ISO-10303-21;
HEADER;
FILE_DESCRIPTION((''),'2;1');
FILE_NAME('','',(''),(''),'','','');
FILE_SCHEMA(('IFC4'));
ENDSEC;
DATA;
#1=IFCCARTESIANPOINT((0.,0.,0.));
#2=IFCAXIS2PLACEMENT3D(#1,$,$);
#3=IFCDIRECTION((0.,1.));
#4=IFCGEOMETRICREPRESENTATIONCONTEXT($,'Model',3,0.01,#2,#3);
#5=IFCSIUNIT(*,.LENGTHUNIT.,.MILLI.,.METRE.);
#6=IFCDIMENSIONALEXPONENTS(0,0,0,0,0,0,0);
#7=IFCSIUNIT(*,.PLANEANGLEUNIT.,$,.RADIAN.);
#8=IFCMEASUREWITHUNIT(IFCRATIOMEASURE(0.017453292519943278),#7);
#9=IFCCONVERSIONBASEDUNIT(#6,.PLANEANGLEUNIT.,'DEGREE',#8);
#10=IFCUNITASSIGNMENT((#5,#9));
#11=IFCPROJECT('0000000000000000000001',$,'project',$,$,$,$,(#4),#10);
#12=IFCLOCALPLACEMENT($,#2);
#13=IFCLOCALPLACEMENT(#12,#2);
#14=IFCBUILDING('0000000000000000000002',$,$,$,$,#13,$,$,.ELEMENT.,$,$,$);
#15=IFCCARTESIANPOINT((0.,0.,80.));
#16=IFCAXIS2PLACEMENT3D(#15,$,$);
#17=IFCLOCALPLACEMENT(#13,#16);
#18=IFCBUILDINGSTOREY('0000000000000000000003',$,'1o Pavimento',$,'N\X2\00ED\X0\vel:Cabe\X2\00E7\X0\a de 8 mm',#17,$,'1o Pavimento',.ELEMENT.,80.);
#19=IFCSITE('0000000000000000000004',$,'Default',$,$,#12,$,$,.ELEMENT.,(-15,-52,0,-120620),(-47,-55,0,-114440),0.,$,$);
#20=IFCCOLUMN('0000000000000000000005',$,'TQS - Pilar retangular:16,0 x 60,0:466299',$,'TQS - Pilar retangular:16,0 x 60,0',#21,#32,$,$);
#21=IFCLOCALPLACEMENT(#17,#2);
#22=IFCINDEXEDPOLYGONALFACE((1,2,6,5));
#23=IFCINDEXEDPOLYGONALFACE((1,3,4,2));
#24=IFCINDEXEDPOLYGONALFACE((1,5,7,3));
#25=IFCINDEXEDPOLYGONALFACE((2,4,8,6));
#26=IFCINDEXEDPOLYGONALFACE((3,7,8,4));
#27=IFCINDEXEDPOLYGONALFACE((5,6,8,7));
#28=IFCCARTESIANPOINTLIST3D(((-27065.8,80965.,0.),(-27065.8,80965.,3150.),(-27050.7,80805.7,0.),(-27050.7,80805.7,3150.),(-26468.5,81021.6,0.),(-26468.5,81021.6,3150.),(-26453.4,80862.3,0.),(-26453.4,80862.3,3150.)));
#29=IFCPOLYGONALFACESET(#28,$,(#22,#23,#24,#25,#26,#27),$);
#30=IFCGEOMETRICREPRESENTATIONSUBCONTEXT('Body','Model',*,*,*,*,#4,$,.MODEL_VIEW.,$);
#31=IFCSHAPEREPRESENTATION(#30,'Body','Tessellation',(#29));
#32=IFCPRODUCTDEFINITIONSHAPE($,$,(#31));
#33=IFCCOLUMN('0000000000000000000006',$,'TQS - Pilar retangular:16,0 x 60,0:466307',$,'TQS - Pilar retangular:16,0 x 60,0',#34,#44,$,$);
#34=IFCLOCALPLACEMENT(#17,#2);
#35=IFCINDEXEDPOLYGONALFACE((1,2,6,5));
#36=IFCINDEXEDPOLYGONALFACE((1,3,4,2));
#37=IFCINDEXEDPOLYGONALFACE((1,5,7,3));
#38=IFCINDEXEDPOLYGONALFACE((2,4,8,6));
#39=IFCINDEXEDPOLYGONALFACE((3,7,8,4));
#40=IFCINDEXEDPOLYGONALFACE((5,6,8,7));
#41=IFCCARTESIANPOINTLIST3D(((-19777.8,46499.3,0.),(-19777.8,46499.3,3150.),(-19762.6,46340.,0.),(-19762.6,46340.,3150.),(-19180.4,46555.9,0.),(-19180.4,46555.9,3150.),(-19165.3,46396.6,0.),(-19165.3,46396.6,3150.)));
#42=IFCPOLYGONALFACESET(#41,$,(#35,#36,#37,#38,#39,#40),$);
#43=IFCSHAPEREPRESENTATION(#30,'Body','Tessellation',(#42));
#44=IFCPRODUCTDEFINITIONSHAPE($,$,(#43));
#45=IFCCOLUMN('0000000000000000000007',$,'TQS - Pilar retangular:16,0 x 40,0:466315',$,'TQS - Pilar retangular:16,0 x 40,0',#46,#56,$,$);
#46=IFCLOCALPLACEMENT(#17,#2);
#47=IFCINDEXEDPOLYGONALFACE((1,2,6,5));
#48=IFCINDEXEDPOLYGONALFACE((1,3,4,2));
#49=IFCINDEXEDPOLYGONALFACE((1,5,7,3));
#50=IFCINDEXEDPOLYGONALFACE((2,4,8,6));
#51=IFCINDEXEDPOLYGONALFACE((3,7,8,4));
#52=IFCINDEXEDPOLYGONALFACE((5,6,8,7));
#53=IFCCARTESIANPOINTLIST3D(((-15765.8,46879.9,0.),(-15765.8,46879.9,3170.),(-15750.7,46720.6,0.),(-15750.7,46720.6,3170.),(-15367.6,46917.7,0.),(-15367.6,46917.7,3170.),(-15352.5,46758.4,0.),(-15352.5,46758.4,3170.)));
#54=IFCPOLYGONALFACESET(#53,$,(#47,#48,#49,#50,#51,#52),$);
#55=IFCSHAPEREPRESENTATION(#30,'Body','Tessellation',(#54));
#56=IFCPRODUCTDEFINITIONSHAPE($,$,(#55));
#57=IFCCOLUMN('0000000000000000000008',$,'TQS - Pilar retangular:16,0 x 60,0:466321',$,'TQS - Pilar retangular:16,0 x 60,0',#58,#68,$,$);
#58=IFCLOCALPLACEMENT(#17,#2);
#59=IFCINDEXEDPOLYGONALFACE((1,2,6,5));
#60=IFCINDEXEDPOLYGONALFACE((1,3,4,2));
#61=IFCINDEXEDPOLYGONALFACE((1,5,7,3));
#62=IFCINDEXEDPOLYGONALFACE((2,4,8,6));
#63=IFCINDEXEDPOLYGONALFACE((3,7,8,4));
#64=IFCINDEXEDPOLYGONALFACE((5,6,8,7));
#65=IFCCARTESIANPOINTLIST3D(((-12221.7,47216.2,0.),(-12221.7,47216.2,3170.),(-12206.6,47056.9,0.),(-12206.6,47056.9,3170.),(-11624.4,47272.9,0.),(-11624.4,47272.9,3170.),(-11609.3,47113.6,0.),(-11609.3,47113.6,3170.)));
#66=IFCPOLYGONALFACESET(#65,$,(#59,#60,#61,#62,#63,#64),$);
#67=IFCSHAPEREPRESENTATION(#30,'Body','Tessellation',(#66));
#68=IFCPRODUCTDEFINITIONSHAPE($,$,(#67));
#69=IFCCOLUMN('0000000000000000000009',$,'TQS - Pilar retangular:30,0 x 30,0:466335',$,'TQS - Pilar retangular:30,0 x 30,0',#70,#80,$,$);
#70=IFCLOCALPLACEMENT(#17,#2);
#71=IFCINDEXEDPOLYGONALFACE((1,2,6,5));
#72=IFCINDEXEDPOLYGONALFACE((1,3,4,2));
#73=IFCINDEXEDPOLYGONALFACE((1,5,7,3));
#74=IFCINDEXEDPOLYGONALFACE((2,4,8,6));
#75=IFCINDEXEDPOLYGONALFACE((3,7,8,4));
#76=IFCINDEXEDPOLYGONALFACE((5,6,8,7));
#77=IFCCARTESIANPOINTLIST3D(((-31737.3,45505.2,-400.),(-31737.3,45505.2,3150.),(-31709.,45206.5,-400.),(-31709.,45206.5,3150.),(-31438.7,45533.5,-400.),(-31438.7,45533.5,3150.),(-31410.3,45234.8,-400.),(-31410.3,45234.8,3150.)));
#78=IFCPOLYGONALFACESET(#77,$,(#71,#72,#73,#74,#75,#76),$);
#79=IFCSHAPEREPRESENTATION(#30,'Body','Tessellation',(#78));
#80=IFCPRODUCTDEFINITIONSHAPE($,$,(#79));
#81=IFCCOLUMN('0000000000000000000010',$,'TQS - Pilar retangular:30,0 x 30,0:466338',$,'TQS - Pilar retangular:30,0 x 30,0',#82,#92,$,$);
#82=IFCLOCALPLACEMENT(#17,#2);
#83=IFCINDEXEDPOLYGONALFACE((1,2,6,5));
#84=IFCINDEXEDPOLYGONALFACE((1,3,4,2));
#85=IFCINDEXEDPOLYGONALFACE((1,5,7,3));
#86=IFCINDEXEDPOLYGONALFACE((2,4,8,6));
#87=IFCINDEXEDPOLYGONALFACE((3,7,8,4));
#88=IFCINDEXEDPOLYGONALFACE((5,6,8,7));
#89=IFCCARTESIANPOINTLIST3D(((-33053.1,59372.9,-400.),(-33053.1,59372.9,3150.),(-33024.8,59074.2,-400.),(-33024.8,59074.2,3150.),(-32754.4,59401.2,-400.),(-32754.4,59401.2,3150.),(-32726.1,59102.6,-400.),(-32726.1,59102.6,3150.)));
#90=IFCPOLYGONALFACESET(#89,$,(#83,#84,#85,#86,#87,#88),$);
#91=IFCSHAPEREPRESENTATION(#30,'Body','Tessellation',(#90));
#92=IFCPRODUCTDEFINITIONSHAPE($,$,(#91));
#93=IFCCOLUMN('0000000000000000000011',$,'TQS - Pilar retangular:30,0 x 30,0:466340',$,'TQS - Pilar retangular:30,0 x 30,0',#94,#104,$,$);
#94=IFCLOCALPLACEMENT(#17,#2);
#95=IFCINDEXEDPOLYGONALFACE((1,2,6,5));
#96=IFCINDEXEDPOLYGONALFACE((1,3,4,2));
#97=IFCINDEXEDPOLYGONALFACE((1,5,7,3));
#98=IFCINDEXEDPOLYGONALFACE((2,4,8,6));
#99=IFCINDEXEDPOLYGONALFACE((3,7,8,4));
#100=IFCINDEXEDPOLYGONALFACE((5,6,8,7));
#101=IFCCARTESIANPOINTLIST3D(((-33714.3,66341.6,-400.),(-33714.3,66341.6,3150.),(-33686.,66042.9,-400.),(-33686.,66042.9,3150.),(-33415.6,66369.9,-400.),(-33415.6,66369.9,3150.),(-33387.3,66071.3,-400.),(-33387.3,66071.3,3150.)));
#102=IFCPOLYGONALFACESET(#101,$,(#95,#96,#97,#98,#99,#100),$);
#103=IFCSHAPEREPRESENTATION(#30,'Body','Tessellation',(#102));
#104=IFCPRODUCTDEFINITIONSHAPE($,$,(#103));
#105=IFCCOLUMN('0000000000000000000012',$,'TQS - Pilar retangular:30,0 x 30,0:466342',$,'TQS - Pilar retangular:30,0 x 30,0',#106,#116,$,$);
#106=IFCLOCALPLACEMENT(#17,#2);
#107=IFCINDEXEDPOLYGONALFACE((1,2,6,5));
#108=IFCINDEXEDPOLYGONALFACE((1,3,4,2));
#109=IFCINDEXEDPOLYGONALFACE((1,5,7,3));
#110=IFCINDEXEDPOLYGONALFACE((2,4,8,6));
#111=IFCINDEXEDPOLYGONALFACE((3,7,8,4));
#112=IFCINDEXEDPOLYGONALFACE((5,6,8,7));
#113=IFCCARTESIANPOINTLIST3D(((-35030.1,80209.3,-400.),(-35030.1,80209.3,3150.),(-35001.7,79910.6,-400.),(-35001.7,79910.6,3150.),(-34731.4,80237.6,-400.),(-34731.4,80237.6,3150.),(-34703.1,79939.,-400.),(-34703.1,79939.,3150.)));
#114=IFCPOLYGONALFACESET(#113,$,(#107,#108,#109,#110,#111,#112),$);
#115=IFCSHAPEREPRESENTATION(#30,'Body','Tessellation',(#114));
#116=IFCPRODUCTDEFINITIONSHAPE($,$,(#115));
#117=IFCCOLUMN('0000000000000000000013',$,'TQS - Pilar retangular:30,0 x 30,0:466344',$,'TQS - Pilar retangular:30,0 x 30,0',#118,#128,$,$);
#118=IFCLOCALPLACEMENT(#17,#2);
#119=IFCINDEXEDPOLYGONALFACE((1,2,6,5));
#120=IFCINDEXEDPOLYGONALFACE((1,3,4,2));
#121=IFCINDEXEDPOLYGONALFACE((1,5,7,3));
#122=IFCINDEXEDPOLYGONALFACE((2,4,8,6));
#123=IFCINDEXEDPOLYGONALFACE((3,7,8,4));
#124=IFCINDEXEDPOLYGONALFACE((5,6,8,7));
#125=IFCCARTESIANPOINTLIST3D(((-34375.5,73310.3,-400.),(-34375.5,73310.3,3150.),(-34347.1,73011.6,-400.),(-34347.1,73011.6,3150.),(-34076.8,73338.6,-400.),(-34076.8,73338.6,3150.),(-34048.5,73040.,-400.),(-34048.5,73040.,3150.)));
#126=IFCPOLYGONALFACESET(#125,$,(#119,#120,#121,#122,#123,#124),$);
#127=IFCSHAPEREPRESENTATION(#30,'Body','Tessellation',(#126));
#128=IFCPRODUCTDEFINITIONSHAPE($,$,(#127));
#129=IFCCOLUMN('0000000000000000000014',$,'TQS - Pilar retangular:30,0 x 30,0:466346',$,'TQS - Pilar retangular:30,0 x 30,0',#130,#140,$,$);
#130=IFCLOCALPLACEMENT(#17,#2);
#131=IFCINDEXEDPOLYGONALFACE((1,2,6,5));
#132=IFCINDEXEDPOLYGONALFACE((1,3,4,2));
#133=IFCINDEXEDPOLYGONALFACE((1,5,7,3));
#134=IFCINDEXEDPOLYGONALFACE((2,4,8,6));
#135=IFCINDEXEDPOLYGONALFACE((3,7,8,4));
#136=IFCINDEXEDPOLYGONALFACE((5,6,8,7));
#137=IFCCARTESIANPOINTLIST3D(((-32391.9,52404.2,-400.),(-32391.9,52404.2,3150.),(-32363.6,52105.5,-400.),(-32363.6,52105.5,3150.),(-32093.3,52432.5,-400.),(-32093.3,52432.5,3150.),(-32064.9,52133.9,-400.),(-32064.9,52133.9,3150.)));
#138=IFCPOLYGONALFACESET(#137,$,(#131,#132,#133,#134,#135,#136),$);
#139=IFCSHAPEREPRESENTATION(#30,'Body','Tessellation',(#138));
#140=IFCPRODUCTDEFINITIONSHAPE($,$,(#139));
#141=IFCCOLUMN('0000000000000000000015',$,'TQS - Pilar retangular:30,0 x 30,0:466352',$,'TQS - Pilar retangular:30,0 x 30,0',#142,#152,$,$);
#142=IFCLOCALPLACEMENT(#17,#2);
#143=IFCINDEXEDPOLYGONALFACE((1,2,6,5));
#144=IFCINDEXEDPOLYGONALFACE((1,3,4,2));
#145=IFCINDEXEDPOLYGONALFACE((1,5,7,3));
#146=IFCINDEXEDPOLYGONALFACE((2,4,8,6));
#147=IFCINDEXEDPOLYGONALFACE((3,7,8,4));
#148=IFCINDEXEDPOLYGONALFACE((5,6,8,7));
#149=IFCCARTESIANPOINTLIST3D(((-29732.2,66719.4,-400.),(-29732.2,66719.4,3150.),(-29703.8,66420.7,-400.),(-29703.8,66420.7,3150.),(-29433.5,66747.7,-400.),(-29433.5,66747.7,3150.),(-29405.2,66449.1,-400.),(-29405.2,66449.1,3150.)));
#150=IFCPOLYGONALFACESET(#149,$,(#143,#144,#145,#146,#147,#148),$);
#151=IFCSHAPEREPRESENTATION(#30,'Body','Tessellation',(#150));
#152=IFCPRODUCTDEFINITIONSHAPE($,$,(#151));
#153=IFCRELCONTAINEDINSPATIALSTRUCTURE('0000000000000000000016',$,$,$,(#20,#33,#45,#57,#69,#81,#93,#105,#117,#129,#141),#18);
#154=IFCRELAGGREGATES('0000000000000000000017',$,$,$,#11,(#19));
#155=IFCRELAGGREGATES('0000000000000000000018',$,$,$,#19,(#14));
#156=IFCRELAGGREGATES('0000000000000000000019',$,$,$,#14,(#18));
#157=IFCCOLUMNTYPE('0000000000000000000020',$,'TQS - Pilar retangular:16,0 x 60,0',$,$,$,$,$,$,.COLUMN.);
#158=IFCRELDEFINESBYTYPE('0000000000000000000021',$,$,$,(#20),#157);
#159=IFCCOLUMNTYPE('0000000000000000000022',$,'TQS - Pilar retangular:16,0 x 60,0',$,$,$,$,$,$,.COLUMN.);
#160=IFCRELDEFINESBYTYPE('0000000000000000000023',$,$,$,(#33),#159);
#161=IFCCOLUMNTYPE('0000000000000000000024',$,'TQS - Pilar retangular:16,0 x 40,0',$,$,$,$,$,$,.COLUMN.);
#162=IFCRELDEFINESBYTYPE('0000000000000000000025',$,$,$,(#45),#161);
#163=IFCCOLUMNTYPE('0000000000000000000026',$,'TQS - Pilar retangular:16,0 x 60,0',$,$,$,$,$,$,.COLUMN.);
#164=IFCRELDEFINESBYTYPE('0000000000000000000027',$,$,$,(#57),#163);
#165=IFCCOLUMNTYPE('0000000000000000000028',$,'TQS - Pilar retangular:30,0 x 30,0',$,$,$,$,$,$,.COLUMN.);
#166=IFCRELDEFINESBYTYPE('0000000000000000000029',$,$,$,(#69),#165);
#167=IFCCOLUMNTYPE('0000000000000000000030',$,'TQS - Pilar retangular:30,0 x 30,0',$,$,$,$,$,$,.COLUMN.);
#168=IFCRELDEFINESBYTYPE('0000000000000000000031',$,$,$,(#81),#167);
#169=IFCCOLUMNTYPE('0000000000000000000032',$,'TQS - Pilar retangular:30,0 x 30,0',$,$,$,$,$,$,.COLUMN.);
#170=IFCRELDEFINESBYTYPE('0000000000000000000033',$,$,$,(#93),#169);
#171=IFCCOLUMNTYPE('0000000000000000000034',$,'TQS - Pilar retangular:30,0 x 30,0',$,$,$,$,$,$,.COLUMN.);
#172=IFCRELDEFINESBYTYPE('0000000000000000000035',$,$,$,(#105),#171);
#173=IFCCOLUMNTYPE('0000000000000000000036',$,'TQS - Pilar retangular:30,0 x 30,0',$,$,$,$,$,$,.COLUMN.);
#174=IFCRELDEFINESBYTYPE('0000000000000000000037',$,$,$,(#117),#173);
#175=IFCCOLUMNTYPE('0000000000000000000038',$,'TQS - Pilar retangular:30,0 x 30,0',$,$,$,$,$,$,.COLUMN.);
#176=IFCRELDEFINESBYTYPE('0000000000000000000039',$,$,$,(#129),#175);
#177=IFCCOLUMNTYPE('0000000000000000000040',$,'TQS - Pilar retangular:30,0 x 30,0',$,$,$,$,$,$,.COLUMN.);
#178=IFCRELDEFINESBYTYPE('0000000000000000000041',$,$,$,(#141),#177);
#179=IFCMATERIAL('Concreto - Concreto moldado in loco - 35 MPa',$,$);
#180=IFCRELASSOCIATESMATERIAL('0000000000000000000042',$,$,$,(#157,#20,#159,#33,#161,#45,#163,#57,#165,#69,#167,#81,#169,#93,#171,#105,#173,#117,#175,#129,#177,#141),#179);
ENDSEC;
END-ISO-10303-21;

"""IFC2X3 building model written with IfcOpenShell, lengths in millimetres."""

from ifc_helpers import new_model, entity, si_unit, converted_unit, direction, frame, frame_2d, origin, origin_2d_with_axis, place, context, subcontext, project, spatial, rectangle, extrude, source, transform, mapped, material, type_object, type_shapes, element, save


model = new_model("IFC2X3")

# Units and contexts
model_context = context("Model", 3, precision=0.01, world=origin(), true_north=direction((0.0, 1.0)))
body_context = subcontext(model_context, "Body", "Model", "MODEL_VIEW")
ifc_project = project(units=[si_unit("LENGTHUNIT", "METRE", prefix="MILLI"), converted_unit("PLANEANGLEUNIT", "DEGREE", entity("IfcRatioMeasure", 0.017453292519943278), si_unit("PLANEANGLEUNIT", "RADIAN"), dimensions=[0, 0, 0, 0, 0, 0, 0])], contexts=[model_context])

# Site, building, storey
site_placement = place(None, origin())
site = spatial("IfcSite", under=ifc_project, at=site_placement, Name="Default", CompositionType="ELEMENT", RefLatitude=(-15, -52, 0, -120620), RefLongitude=(-47, -55, 0, -114440), RefElevation=0.0)
building_placement = place(site_placement, origin())
building = spatial("IfcBuilding", under=site, at=building_placement, CompositionType="ELEMENT")
storey_placement = place(building_placement, frame((0.0, 0.0, 80.0)))
storey = spatial("IfcBuildingStorey", under=building, at=storey_placement, Name="1o Pavimento", ObjectType="Nível:Cabeça de 8 mm", LongName="1o Pavimento", CompositionType="ELEMENT", Elevation=80.0)

# Columns
ifc_material = material(Name="Concreto - Concreto moldado in loco - 35 MPa")
column_type_1 = type_object("IfcColumnType", Name="TQS - Pilar retangular:16,0 x 60,0", PredefinedType="COLUMN", material=ifc_material)
shared_shape_1 = source(origin(), body_context, "Body", "SweptSolid", [
    extrude(rectangle(XDim=600.0, YDim=160.0, at=origin_2d_with_axis()), frame((-26759.6, 80913.6, 80.0), z_axis=(0.0, 0.0, 1.0), x_axis=(-0.995529, -0.094456, 0.0)), (0.0, 0.0, 1.0), 3150.0),
])
type_shapes(column_type_1, [shared_shape_1])
column_1_placement = place(storey_placement, frame((0.0, 0.0, -80.0)))
element("IfcColumn", 1, at=column_1_placement, inside=storey, type_object=column_type_1, material=ifc_material, Name="TQS - Pilar retangular:16,0 x 60,0:466299", ObjectType="TQS - Pilar retangular:16,0 x 60,0", context=body_context, shape_type="MappedRepresentation", body=[
    mapped(shared_shape_1, transform((0.0, 0.0, 0.0), scale=1.0)),
])
column_type_2 = type_object("IfcColumnType", Name="TQS - Pilar retangular:16,0 x 60,0", PredefinedType="COLUMN", material=ifc_material)
shared_shape_2 = source(origin(), body_context, "Body", "SweptSolid", [
    extrude(rectangle(XDim=600.0, YDim=160.0, at=origin_2d_with_axis()), frame((-19471.5, 46448.0, 80.0), z_axis=(0.0, 0.0, 1.0), x_axis=(-0.995529, -0.094456, 0.0)), (0.0, 0.0, 1.0), 3150.0),
])
type_shapes(column_type_2, [shared_shape_2])
column_2_placement = place(storey_placement, frame((0.0, 0.0, -80.0)))
element("IfcColumn", 2, at=column_2_placement, inside=storey, type_object=column_type_2, material=ifc_material, Name="TQS - Pilar retangular:16,0 x 60,0:466307", ObjectType="TQS - Pilar retangular:16,0 x 60,0", context=body_context, shape_type="MappedRepresentation", body=[
    mapped(shared_shape_2, transform((0.0, 0.0, 0.0), scale=1.0)),
])
column_type_3 = type_object("IfcColumnType", Name="TQS - Pilar retangular:16,0 x 40,0", PredefinedType="COLUMN", material=ifc_material)
shared_shape_3 = source(origin(), body_context, "Body", "SweptSolid", [
    extrude(rectangle(XDim=400.0, YDim=160.0, at=frame_2d((0.0, 0.0), x_axis=(1.0, 0.0))), frame((-15559.1, 46819.2, 80.0), z_axis=(0.0, 0.0, 1.0), x_axis=(-0.995529, -0.094456, 0.0)), (0.0, 0.0, 1.0), 3170.0),
])
type_shapes(column_type_3, [shared_shape_3])
column_3_placement = place(storey_placement, frame((0.0, 0.0, -80.0)))
element("IfcColumn", 3, at=column_3_placement, inside=storey, type_object=column_type_3, material=ifc_material, Name="TQS - Pilar retangular:16,0 x 40,0:466315", ObjectType="TQS - Pilar retangular:16,0 x 40,0", context=body_context, shape_type="MappedRepresentation", body=[
    mapped(shared_shape_3, transform((0.0, 0.0, 0.0), scale=1.0)),
])
column_type_4 = type_object("IfcColumnType", Name="TQS - Pilar retangular:16,0 x 60,0", PredefinedType="COLUMN", material=ifc_material)
shared_shape_4 = source(origin(), body_context, "Body", "SweptSolid", [
    extrude(rectangle(XDim=600.0, YDim=160.0, at=frame_2d((0.0, 0.0), x_axis=(1.0, 0.0))), frame((-11915.5, 47164.9, 80.0), z_axis=(0.0, 0.0, 1.0), x_axis=(-0.995529, -0.094456, 0.0)), (0.0, 0.0, 1.0), 3170.0),
])
type_shapes(column_type_4, [shared_shape_4])
column_4_placement = place(storey_placement, frame((0.0, 0.0, -80.0)))
element("IfcColumn", 4, at=column_4_placement, inside=storey, type_object=column_type_4, material=ifc_material, Name="TQS - Pilar retangular:16,0 x 60,0:466321", ObjectType="TQS - Pilar retangular:16,0 x 60,0", context=body_context, shape_type="MappedRepresentation", body=[
    mapped(shared_shape_4, transform((0.0, 0.0, 0.0), scale=1.0)),
])
column_type_5 = type_object("IfcColumnType", Name="TQS - Pilar retangular:30,0 x 30,0", PredefinedType="COLUMN", material=ifc_material)
shared_shape_5 = source(origin(), body_context, "Body", "SweptSolid", [
    extrude(rectangle(XDim=300.0, YDim=300.0, at=origin_2d_with_axis()), frame((-31573.8, 45370.0, -320.0), z_axis=(0.0, 0.0, 1.0), x_axis=(-0.995529, -0.094456, 0.0)), (0.0, 0.0, 1.0), 3550.0),
])
type_shapes(column_type_5, [shared_shape_5])
column_5_placement = place(storey_placement, frame((0.0, 0.0, -80.0)))
element("IfcColumn", 5, at=column_5_placement, inside=storey, type_object=column_type_5, material=ifc_material, Name="TQS - Pilar retangular:30,0 x 30,0:466335", ObjectType="TQS - Pilar retangular:30,0 x 30,0", context=body_context, shape_type="MappedRepresentation", body=[
    mapped(shared_shape_5, transform((0.0, 0.0, 0.0), scale=1.0)),
])
column_type_6 = type_object("IfcColumnType", Name="TQS - Pilar retangular:30,0 x 30,0", PredefinedType="COLUMN", material=ifc_material)
shared_shape_6 = source(origin(), body_context, "Body", "SweptSolid", [
    extrude(rectangle(XDim=300.0, YDim=300.0, at=origin_2d_with_axis()), frame((-32889.6, 59237.7, -320.0), z_axis=(0.0, 0.0, 1.0), x_axis=(-0.995529, -0.094456, 0.0)), (0.0, 0.0, 1.0), 3550.0),
])
type_shapes(column_type_6, [shared_shape_6])
column_6_placement = place(storey_placement, frame((0.0, 0.0, -80.0)))
element("IfcColumn", 6, at=column_6_placement, inside=storey, type_object=column_type_6, material=ifc_material, Name="TQS - Pilar retangular:30,0 x 30,0:466338", ObjectType="TQS - Pilar retangular:30,0 x 30,0", context=body_context, shape_type="MappedRepresentation", body=[
    mapped(shared_shape_6, transform((0.0, 0.0, 0.0), scale=1.0)),
])
column_type_7 = type_object("IfcColumnType", Name="TQS - Pilar retangular:30,0 x 30,0", PredefinedType="COLUMN", material=ifc_material)
shared_shape_7 = source(origin(), body_context, "Body", "SweptSolid", [
    extrude(rectangle(XDim=300.0, YDim=300.0, at=origin_2d_with_axis()), frame((-33550.8, 66206.4, -320.0), z_axis=(0.0, 0.0, 1.0), x_axis=(-0.995529, -0.094456, 0.0)), (0.0, 0.0, 1.0), 3550.0),
])
type_shapes(column_type_7, [shared_shape_7])
column_7_placement = place(storey_placement, frame((0.0, 0.0, -80.0)))
element("IfcColumn", 7, at=column_7_placement, inside=storey, type_object=column_type_7, material=ifc_material, Name="TQS - Pilar retangular:30,0 x 30,0:466340", ObjectType="TQS - Pilar retangular:30,0 x 30,0", context=body_context, shape_type="MappedRepresentation", body=[
    mapped(shared_shape_7, transform((0.0, 0.0, 0.0), scale=1.0)),
])
column_type_8 = type_object("IfcColumnType", Name="TQS - Pilar retangular:30,0 x 30,0", PredefinedType="COLUMN", material=ifc_material)
shared_shape_8 = source(origin(), body_context, "Body", "SweptSolid", [
    extrude(rectangle(XDim=300.0, YDim=300.0, at=origin_2d_with_axis()), frame((-34866.6, 80074.1, -320.0), z_axis=(0.0, 0.0, 1.0), x_axis=(-0.995529, -0.094456, 0.0)), (0.0, 0.0, 1.0), 3550.0),
])
type_shapes(column_type_8, [shared_shape_8])
column_8_placement = place(storey_placement, frame((0.0, 0.0, -80.0)))
element("IfcColumn", 8, at=column_8_placement, inside=storey, type_object=column_type_8, material=ifc_material, Name="TQS - Pilar retangular:30,0 x 30,0:466342", ObjectType="TQS - Pilar retangular:30,0 x 30,0", context=body_context, shape_type="MappedRepresentation", body=[
    mapped(shared_shape_8, transform((0.0, 0.0, 0.0), scale=1.0)),
])
column_type_9 = type_object("IfcColumnType", Name="TQS - Pilar retangular:30,0 x 30,0", PredefinedType="COLUMN", material=ifc_material)
shared_shape_9 = source(origin(), body_context, "Body", "SweptSolid", [
    extrude(rectangle(XDim=300.0, YDim=300.0, at=origin_2d_with_axis()), frame((-34212.0, 73175.1, -320.0), z_axis=(0.0, 0.0, 1.0), x_axis=(-0.995529, -0.094456, 0.0)), (0.0, 0.0, 1.0), 3550.0),
])
type_shapes(column_type_9, [shared_shape_9])
column_9_placement = place(storey_placement, frame((0.0, 0.0, -80.0)))
element("IfcColumn", 9, at=column_9_placement, inside=storey, type_object=column_type_9, material=ifc_material, Name="TQS - Pilar retangular:30,0 x 30,0:466344", ObjectType="TQS - Pilar retangular:30,0 x 30,0", context=body_context, shape_type="MappedRepresentation", body=[
    mapped(shared_shape_9, transform((0.0, 0.0, 0.0), scale=1.0)),
])
column_type_10 = type_object("IfcColumnType", Name="TQS - Pilar retangular:30,0 x 30,0", PredefinedType="COLUMN", material=ifc_material)
shared_shape_10 = source(origin(), body_context, "Body", "SweptSolid", [
    extrude(rectangle(XDim=300.0, YDim=300.0, at=origin_2d_with_axis()), frame((-32228.4, 52269.0, -320.0), z_axis=(0.0, 0.0, 1.0), x_axis=(-0.995529, -0.094456, 0.0)), (0.0, 0.0, 1.0), 3550.0),
])
type_shapes(column_type_10, [shared_shape_10])
column_10_placement = place(storey_placement, frame((0.0, 0.0, -80.0)))
element("IfcColumn", 10, at=column_10_placement, inside=storey, type_object=column_type_10, material=ifc_material, Name="TQS - Pilar retangular:30,0 x 30,0:466346", ObjectType="TQS - Pilar retangular:30,0 x 30,0", context=body_context, shape_type="MappedRepresentation", body=[
    mapped(shared_shape_10, transform((0.0, 0.0, 0.0), scale=1.0)),
])
column_type_11 = type_object("IfcColumnType", Name="TQS - Pilar retangular:30,0 x 30,0", PredefinedType="COLUMN", material=ifc_material)
shared_shape_11 = source(origin(), body_context, "Body", "SweptSolid", [
    extrude(rectangle(XDim=300.0, YDim=300.0, at=frame_2d((0.0, 0.0), x_axis=(1.0, 0.0))), frame((-29568.7, 66584.2, -320.0), z_axis=(0.0, 0.0, 1.0), x_axis=(-0.995529, -0.094456, 0.0)), (0.0, 0.0, 1.0), 3550.0),
])
type_shapes(column_type_11, [shared_shape_11])
column_11_placement = place(storey_placement, frame((0.0, 0.0, -80.0)))
element("IfcColumn", 11, at=column_11_placement, inside=storey, type_object=column_type_11, material=ifc_material, Name="TQS - Pilar retangular:30,0 x 30,0:466352", ObjectType="TQS - Pilar retangular:30,0 x 30,0", context=body_context, shape_type="MappedRepresentation", body=[
    mapped(shared_shape_11, transform((0.0, 0.0, 0.0), scale=1.0)),
])

save(model, "model.ifc")
